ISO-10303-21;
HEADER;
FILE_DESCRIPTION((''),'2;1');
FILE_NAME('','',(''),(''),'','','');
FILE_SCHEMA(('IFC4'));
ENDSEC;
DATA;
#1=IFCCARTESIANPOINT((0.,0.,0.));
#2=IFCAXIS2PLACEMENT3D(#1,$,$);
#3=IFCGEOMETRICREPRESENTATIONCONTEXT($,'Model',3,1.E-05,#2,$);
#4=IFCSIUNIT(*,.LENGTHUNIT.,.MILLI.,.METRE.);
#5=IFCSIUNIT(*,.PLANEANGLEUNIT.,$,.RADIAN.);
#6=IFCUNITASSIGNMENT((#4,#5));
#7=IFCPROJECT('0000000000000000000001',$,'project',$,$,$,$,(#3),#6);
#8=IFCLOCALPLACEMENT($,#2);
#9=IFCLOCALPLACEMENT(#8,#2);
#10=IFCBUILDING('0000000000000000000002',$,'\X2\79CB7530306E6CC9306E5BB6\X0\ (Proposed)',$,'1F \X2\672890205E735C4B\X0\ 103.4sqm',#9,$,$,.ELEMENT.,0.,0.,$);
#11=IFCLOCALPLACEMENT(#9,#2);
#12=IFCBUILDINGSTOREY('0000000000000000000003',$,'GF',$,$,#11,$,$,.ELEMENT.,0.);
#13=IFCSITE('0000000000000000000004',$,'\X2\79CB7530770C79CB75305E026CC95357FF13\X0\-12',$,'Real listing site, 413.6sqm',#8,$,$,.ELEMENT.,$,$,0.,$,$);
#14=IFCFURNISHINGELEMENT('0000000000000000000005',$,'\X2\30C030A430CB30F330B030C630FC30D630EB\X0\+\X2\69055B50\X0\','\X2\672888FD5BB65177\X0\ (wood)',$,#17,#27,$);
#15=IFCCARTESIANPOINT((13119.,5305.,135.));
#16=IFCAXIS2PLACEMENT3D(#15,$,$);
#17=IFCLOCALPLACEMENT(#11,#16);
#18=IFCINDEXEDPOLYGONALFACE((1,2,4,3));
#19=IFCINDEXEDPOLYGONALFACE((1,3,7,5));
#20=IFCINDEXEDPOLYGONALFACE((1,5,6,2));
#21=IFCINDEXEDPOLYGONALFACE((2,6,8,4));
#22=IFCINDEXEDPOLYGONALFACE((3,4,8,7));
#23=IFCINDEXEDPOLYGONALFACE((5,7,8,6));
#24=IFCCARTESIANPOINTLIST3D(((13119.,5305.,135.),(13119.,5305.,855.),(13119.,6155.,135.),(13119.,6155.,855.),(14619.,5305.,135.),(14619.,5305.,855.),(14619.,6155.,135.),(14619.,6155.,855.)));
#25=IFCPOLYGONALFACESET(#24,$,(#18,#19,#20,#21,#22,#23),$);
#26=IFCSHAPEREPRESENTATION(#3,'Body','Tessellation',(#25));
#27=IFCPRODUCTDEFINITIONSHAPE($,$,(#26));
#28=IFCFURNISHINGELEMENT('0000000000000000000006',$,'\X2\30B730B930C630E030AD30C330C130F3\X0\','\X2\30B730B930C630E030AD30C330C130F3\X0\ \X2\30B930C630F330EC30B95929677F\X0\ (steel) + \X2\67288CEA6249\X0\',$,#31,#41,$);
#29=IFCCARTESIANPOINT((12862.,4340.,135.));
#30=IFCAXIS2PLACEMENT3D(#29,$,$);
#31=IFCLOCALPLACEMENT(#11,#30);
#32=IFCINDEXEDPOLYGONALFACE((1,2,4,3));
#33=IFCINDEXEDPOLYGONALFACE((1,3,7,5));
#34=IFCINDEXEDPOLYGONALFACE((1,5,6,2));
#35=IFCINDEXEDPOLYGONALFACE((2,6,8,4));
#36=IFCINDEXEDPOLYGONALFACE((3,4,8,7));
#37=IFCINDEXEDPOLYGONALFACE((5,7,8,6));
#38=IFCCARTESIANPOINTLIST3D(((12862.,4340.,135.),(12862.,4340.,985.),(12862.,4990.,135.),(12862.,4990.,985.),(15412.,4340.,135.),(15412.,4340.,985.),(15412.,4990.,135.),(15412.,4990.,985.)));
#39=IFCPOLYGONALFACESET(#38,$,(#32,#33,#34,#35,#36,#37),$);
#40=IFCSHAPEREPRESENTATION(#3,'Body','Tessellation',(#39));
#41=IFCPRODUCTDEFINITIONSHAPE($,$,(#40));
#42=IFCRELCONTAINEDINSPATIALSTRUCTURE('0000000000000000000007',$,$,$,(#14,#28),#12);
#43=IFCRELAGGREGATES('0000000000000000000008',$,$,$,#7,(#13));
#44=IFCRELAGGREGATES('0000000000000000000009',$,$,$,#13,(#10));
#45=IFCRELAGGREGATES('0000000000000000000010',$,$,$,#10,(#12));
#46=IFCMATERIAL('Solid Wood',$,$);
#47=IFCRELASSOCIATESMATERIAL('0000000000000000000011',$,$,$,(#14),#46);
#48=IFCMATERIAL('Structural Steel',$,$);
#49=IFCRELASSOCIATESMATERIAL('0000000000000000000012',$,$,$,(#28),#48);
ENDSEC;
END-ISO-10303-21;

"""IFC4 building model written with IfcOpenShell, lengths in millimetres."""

from ifc_helpers import new_model, si_unit, frame, frame_2d, origin, place, context, project, spatial, rectangle, extrude, material, element, save


model = new_model("IFC4")

# Units and contexts
model_context = context("Model", 3, precision=1e-05, world=origin())
ifc_project = project(units=[si_unit("LENGTHUNIT", "METRE", prefix="MILLI"), si_unit("PLANEANGLEUNIT", "RADIAN")], contexts=[model_context])

# Site, building, storey
site_placement = place(None, origin())
site = spatial("IfcSite", under=ifc_project, at=site_placement, Name="秋田県秋田市泉南３-12", ObjectType="Real listing site, 413.6sqm", CompositionType="ELEMENT", RefElevation=0.0)
building_placement = place(site_placement, origin())
building = spatial("IfcBuilding", under=site, at=building_placement, Name="秋田の泉の家 (Proposed)", ObjectType="1F 木造平屋 103.4sqm", CompositionType="ELEMENT", ElevationOfRefHeight=0.0, ElevationOfTerrain=0.0)
storey_placement = place(building_placement, origin())
storey = spatial("IfcBuildingStorey", under=building, at=storey_placement, Name="GF", CompositionType="ELEMENT", Elevation=0.0)

# Shared definitions
ifc_material_1 = material(Name="Solid Wood")

# Shared definitions
ifc_material_2 = material(Name="Structural Steel")

# Furnishing elements
furnishing_1_placement = place(storey_placement, frame((13119.0, 5305.0, 135.0)))
element("IfcFurnishingElement", 1, at=furnishing_1_placement, inside=storey, material=ifc_material_1, Name="ダイニングテーブル+椅子", Description="木製家具 (wood)", context=model_context, shape_type="SweptSolid", body=[
    extrude(rectangle(XDim=1500.0, YDim=850.0, at=frame_2d((750.0, 425.0))), frame((13119.0, 5305.0, 135.0)), (0.0, 0.0, 1.0), 720.0),
])
furnishing_2_placement = place(storey_placement, frame((12862.0, 4340.0, 135.0)))
element("IfcFurnishingElement", 2, at=furnishing_2_placement, inside=storey, material=ifc_material_2, Name="システムキッチン", Description="システムキッチン ステンレス天板 (steel) + 木質扉", context=model_context, shape_type="SweptSolid", body=[
    extrude(rectangle(XDim=2550.0, YDim=650.0, at=frame_2d((1275.0, 325.0))), frame((12862.0, 4340.0, 135.0)), (0.0, 0.0, 1.0), 850.0),
])

save(model, "model.ifc")
